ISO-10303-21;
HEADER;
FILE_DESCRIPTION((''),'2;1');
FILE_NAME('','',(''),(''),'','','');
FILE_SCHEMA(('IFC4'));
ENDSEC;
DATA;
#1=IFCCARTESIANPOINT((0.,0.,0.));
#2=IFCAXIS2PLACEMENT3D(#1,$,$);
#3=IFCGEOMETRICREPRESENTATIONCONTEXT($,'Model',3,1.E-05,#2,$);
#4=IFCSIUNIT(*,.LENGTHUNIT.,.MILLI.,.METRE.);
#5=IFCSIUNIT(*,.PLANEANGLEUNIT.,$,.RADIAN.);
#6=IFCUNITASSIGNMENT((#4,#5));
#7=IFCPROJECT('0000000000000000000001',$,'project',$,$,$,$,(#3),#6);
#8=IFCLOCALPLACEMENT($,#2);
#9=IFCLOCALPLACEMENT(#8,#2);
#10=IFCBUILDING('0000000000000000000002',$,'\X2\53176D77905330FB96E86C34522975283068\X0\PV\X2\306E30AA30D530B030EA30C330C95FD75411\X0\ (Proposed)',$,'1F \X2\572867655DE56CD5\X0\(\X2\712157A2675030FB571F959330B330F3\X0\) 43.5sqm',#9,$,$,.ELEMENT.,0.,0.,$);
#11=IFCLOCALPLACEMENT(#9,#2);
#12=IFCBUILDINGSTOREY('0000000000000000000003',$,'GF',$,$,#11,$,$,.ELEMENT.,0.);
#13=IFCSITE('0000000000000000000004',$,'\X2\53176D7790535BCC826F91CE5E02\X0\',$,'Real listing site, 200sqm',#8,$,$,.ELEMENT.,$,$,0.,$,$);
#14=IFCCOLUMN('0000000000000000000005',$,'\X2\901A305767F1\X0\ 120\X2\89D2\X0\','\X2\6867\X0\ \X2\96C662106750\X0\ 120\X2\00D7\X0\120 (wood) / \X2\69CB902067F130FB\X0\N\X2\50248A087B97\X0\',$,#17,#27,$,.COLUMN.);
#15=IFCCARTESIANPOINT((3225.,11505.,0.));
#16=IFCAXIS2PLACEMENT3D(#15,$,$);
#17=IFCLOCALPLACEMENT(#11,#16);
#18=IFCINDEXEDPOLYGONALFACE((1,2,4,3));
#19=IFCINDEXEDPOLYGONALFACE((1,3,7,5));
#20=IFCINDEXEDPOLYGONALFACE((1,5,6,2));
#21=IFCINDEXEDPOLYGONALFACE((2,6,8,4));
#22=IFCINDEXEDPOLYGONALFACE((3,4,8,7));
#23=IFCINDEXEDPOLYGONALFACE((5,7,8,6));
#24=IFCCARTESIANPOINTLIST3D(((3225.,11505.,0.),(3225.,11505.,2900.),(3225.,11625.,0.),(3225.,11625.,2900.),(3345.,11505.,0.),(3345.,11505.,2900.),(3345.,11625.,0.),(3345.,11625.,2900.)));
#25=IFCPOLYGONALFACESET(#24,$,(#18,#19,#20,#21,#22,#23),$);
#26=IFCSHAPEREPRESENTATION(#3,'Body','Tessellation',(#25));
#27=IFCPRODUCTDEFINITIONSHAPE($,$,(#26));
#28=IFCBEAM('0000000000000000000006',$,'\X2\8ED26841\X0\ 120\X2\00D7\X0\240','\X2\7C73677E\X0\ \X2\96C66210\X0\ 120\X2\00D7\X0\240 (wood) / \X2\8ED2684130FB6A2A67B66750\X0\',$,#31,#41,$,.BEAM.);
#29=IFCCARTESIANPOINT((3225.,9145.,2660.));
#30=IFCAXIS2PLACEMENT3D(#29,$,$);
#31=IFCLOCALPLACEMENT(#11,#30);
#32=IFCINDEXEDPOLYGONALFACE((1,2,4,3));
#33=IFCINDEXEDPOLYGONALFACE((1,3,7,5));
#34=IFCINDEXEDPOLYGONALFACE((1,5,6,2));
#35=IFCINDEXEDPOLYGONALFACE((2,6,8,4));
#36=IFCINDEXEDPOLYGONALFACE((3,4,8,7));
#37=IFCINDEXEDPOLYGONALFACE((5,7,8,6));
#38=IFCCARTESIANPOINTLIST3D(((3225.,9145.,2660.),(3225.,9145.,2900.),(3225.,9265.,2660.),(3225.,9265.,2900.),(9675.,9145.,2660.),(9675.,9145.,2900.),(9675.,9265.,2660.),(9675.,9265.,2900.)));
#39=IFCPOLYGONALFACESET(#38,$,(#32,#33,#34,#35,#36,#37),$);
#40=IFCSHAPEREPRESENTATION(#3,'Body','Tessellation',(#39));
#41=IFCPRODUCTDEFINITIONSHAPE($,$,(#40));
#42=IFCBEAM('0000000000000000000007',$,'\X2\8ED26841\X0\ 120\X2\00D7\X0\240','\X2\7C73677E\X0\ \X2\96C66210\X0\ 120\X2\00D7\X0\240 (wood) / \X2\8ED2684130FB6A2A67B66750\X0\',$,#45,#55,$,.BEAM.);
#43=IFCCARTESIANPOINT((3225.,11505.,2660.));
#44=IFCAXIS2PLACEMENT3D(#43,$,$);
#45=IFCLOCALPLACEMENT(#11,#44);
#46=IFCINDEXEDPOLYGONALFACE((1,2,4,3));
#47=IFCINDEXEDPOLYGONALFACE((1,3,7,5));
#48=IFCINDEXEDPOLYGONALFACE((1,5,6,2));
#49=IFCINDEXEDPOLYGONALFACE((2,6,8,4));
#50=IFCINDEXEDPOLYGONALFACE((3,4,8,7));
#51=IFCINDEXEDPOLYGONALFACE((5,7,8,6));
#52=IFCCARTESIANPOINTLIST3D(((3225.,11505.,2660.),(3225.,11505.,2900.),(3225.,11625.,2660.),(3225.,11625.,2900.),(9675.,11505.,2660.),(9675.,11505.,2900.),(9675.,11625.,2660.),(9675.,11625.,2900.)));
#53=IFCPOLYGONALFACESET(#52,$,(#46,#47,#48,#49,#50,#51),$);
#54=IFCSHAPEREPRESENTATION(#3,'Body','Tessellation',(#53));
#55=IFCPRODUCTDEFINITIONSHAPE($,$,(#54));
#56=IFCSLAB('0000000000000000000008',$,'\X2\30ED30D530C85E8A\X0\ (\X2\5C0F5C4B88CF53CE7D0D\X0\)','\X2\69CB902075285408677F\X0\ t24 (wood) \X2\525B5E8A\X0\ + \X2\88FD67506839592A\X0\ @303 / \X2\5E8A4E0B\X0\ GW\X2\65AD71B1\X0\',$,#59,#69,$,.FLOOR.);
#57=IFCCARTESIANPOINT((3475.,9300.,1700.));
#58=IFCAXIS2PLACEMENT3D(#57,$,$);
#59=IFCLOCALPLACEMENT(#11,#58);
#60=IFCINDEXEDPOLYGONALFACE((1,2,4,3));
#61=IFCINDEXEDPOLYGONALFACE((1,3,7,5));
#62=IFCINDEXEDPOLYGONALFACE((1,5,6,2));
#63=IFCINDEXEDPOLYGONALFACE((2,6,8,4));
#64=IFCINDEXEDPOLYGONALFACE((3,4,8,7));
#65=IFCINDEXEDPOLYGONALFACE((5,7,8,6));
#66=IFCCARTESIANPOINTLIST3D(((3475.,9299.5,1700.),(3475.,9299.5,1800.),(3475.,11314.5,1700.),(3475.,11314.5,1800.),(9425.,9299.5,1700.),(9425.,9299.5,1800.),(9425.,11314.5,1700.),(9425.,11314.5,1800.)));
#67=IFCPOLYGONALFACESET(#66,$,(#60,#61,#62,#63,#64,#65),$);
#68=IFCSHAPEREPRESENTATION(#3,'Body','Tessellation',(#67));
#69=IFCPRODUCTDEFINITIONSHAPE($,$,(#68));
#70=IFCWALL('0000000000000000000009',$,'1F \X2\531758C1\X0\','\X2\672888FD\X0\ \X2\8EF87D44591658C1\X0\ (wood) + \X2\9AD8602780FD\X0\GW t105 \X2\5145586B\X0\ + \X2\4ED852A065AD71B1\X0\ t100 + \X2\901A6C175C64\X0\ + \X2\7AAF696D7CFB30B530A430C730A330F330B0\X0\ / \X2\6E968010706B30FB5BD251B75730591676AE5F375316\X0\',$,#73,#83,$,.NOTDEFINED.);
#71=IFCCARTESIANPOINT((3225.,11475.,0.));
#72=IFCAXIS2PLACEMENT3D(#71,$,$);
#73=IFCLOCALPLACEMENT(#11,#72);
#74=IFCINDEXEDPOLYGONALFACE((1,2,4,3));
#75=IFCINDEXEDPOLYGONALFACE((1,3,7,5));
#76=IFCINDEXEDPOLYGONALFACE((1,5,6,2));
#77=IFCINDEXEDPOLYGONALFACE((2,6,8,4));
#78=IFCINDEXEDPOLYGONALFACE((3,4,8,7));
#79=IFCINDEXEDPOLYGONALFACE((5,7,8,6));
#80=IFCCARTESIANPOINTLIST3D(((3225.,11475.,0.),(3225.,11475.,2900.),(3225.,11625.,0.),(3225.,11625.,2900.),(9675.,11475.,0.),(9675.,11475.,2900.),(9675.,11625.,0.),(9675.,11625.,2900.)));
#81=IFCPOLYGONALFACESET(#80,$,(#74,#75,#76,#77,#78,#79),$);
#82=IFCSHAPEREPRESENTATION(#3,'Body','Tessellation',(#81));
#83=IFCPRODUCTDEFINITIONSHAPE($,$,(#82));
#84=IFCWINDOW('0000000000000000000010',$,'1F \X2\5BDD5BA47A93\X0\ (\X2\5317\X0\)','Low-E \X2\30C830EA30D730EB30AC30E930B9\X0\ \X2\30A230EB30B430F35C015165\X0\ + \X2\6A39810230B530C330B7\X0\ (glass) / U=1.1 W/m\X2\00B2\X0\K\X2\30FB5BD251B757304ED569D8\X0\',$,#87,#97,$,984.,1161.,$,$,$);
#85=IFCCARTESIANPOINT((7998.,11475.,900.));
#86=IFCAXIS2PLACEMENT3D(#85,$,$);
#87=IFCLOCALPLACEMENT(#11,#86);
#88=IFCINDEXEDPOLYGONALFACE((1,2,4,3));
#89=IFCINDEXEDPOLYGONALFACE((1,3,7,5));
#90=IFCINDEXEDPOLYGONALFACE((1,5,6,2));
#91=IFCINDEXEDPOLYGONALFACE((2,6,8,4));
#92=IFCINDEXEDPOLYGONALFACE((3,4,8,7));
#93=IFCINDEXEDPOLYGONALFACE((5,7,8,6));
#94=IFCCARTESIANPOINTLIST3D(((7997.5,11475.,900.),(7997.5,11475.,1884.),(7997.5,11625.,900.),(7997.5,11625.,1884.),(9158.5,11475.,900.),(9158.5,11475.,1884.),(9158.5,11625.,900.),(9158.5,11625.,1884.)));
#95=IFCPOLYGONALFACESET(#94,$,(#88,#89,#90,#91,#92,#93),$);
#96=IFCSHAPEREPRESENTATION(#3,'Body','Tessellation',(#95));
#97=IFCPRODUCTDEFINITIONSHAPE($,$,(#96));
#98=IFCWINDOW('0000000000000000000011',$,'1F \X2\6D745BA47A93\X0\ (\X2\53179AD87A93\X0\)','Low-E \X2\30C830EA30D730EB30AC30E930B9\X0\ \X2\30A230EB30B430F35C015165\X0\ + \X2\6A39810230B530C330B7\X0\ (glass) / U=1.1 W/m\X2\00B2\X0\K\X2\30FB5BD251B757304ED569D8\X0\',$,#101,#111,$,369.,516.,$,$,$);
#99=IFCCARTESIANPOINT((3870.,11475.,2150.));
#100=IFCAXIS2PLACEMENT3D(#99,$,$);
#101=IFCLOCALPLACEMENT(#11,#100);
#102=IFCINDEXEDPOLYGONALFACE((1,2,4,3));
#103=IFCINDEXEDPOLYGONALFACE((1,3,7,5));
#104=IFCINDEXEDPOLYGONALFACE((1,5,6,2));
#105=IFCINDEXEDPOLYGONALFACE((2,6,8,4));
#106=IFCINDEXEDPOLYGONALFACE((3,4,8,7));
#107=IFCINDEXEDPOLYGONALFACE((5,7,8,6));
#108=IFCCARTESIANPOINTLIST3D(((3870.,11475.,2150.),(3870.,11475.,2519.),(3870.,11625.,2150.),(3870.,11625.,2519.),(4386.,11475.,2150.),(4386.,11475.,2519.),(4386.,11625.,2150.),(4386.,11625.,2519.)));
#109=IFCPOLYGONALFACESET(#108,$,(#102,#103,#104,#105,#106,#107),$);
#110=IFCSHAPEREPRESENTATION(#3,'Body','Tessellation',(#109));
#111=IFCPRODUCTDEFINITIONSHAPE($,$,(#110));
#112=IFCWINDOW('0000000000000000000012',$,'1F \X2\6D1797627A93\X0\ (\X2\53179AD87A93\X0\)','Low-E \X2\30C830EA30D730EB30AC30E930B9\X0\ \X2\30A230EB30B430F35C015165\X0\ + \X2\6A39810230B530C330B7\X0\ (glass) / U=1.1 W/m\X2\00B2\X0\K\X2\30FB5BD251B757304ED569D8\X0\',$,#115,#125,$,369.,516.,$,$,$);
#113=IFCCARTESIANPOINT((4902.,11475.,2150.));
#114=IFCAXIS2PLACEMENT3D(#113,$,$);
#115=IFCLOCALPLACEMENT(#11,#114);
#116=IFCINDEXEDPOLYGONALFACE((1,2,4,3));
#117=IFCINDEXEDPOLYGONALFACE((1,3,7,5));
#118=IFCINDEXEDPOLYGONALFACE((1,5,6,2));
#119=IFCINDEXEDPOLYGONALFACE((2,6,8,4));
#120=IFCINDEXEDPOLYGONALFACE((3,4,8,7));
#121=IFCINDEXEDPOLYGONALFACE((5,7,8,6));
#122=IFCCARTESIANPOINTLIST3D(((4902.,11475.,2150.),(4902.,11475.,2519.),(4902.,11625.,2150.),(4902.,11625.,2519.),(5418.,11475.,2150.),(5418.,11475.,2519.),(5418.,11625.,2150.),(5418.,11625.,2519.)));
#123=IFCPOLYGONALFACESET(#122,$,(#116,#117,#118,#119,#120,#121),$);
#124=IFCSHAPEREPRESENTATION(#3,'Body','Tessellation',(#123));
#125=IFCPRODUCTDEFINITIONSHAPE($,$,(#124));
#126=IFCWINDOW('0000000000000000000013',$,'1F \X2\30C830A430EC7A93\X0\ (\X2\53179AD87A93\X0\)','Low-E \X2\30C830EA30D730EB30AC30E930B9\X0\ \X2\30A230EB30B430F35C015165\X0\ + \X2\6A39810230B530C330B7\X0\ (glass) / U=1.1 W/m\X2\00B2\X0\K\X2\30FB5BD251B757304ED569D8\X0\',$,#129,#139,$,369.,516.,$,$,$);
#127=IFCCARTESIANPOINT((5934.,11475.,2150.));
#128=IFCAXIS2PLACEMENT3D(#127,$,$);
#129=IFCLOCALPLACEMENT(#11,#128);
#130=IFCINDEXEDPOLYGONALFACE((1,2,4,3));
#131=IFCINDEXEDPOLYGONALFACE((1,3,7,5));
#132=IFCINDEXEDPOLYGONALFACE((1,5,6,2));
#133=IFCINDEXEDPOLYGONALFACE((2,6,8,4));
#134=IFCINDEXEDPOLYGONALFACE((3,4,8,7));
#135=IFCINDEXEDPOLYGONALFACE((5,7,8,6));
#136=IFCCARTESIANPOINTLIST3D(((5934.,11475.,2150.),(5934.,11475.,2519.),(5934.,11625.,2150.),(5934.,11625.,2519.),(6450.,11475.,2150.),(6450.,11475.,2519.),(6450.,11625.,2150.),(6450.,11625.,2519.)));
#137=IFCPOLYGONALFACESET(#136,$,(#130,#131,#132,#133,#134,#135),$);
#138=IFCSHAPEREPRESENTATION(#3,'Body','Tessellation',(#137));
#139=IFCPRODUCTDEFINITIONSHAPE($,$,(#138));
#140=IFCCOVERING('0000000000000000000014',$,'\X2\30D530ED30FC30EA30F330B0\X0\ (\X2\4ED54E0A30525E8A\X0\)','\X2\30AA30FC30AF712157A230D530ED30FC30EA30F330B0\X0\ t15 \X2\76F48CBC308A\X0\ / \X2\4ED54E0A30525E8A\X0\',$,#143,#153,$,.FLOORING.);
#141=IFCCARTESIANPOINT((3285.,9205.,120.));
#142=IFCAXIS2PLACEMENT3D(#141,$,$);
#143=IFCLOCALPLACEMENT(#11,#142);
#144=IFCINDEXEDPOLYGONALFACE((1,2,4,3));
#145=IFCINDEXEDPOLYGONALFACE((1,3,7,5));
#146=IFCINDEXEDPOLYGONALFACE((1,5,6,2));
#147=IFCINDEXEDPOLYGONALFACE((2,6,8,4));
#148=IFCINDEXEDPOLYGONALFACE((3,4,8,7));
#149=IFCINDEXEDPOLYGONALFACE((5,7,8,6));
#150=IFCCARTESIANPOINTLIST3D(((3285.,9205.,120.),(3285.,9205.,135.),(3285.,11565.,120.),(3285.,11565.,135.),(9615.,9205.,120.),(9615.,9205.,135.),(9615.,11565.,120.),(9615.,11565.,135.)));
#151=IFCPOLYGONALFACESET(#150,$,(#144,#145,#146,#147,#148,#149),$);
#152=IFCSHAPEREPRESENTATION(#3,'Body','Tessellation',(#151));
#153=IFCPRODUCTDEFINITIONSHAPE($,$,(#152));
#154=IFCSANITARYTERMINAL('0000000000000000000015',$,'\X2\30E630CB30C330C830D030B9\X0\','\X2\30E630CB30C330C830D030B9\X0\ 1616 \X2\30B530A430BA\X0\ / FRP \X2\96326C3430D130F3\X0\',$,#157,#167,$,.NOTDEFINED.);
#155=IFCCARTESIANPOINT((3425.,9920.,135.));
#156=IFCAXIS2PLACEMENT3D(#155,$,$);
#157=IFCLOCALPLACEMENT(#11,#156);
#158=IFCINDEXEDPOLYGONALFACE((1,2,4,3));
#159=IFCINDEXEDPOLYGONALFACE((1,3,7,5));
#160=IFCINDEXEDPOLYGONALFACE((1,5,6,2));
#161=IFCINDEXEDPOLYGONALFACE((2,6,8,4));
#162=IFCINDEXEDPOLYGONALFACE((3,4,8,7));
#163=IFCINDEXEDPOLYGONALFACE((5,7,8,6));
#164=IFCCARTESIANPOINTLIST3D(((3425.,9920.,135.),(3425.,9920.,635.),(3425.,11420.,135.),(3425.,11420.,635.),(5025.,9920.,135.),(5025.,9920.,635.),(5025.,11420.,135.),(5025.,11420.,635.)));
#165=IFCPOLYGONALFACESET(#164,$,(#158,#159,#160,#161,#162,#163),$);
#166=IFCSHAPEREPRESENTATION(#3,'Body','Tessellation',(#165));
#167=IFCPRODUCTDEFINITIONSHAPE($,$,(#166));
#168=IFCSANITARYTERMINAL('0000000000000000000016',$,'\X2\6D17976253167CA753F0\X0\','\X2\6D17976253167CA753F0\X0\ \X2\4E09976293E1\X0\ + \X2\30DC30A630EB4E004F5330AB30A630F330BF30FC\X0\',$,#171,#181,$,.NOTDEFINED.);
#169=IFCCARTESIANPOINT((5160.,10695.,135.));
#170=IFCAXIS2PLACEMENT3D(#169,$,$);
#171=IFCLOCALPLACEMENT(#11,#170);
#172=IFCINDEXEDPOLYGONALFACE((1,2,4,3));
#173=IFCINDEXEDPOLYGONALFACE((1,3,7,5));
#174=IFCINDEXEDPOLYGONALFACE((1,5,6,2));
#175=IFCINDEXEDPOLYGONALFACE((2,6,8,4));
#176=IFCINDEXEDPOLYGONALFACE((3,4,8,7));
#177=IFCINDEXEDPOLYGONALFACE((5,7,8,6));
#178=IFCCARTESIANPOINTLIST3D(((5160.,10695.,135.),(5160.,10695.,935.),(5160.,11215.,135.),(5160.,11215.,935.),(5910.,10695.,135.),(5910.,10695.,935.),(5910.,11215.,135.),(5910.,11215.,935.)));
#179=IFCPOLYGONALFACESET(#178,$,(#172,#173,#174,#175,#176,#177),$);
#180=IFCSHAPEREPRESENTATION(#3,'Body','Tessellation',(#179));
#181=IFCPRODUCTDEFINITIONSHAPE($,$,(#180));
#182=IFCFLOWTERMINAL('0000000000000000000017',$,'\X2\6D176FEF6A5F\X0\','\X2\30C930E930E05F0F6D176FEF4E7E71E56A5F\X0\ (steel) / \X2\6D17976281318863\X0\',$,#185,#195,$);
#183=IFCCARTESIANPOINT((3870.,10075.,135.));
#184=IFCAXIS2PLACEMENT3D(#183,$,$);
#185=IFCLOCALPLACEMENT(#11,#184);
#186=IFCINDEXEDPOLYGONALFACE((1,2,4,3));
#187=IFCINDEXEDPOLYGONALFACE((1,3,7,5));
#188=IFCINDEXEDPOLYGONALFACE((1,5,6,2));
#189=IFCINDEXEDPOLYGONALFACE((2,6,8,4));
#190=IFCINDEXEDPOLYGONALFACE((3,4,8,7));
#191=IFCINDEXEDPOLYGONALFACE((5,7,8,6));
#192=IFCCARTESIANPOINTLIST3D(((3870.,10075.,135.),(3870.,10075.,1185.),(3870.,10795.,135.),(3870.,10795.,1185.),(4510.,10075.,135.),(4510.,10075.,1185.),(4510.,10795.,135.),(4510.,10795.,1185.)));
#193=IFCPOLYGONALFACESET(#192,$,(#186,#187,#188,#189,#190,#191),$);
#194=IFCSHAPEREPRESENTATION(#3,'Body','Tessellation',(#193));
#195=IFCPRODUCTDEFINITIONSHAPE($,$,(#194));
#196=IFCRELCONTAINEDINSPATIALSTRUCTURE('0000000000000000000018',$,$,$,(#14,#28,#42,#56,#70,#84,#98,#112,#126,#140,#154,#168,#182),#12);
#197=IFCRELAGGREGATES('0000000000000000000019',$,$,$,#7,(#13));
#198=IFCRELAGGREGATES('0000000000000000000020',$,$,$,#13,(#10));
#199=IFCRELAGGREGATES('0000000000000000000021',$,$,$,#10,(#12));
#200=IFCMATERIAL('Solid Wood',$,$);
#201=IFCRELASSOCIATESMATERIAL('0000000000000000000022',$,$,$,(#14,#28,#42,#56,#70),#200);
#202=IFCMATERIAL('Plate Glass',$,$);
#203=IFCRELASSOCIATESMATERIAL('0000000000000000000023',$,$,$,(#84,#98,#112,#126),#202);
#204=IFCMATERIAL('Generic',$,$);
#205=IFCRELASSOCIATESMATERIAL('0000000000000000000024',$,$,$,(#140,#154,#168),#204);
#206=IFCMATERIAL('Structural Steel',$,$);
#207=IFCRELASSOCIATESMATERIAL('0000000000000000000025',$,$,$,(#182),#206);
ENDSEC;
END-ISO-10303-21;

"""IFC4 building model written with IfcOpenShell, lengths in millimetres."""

from ifc_helpers import new_model, si_unit, frame, frame_2d, origin, place, context, project, spatial, rectangle, extrude, material, element, fill, save


model = new_model("IFC4")

# Units and contexts
model_context = context("Model", 3, precision=1e-05, world=origin())
ifc_project = project(units=[si_unit("LENGTHUNIT", "METRE", prefix="MILLI"), si_unit("PLANEANGLEUNIT", "RADIAN")], contexts=[model_context])

# Site, building, storey
site_placement = place(None, origin())
site = spatial("IfcSite", under=ifc_project, at=site_placement, Name="北海道富良野市", ObjectType="Real listing site, 200sqm", CompositionType="ELEMENT", RefElevation=0.0)
building_placement = place(site_placement, origin())
building = spatial("IfcBuilding", under=site, at=building_placement, Name="北海道・雨水利用とPVのオフグリッド志向 (Proposed)", ObjectType="1F 在来工法(無垢材・土間コン) 43.5sqm", CompositionType="ELEMENT", ElevationOfRefHeight=0.0, ElevationOfTerrain=0.0)
storey_placement = place(building_placement, origin())
storey = spatial("IfcBuildingStorey", under=building, at=storey_placement, Name="GF", CompositionType="ELEMENT", Elevation=0.0)

# Column
ifc_material_1 = material(Name="Solid Wood")
column_placement = place(storey_placement, frame((3225.0, 11505.0, 0.0)))
element("IfcColumn", 1, at=column_placement, inside=storey, material=ifc_material_1, Name="通し柱 120角", Description="桧 集成材 120×120 (wood) / 構造柱・N値計算", PredefinedType="COLUMN", context=model_context, shape_type="SweptSolid", body=[
    extrude(rectangle(XDim=120.0, YDim=120.0, at=frame_2d((60.0, 60.0))), frame((3225.0, 11505.0, 0.0)), (0.0, 0.0, 1.0), 2900.0),
])

# Beams
beam_1_placement = place(storey_placement, frame((3225.0, 9145.0, 2660.0)))
element("IfcBeam", 2, at=beam_1_placement, inside=storey, material=ifc_material_1, Name="軒桁 120×240", Description="米松 集成 120×240 (wood) / 軒桁・横架材", PredefinedType="BEAM", context=model_context, shape_type="SweptSolid", body=[
    extrude(rectangle(XDim=6450.0, YDim=120.0, at=frame_2d((3225.0, 60.0))), frame((3225.0, 9145.0, 2660.0)), (0.0, 0.0, 1.0), 240.0),
])
beam_2_placement = place(storey_placement, frame((3225.0, 11505.0, 2660.0)))
element("IfcBeam", 3, at=beam_2_placement, inside=storey, material=ifc_material_1, Name="軒桁 120×240", Description="米松 集成 120×240 (wood) / 軒桁・横架材", PredefinedType="BEAM", context=model_context, shape_type="SweptSolid", body=[
    extrude(rectangle(XDim=6450.0, YDim=120.0, at=frame_2d((3225.0, 60.0))), frame((3225.0, 11505.0, 2660.0)), (0.0, 0.0, 1.0), 240.0),
])

# Slab
slab_placement = place(storey_placement, frame((3475.0, 9300.0, 1700.0)))
element("IfcSlab", 4, at=slab_placement, inside=storey, material=ifc_material_1, Name="ロフト床 (小屋裏収納)", Description="構造用合板 t24 (wood) 剛床 + 製材根太 @303 / 床下 GW断熱", PredefinedType="FLOOR", context=model_context, shape_type="SweptSolid", body=[
    extrude(rectangle(XDim=5950.0, YDim=2015.0, at=frame_2d((2975.0, 1007.0))), frame((3475.0, 9300.0, 1700.0)), (0.0, 0.0, 1.0), 100.0),
])

# Wall, openings, windows
wall_1_placement = place(storey_placement, frame((3225.0, 11475.0, 0.0)))
wall_1 = element("IfcWall", 5, at=wall_1_placement, inside=storey, material=ifc_material_1, Name="1F 北壁", Description="木製 軸組外壁 (wood) + 高性能GW t105 充填 + 付加断熱 t100 + 通気層 + 窯業系サイディング / 準耐火・寒冷地外皮強化", PredefinedType="NOTDEFINED", context=model_context, shape_type="SweptSolid", body=[
    extrude(rectangle(XDim=6450.0, YDim=150.0, at=frame_2d((3225.0, 75.0))), frame((3225.0, 11475.0, 0.0)), (0.0, 0.0, 1.0), 2900.0),
])
opening_1_placement = place(storey_placement, frame((7998.0, 11475.0, 900.0)))
opening_1 = element("IfcOpeningElement", 6, at=opening_1_placement, cuts=wall_1, PredefinedType="NOTDEFINED", context=model_context, shape_type="SweptSolid", body=[
    extrude(rectangle(XDim=1161.0, YDim=150.0, at=frame_2d((580.0, 75.0))), frame((7998.0, 11475.0, 900.0)), (0.0, 0.0, 1.0), 984.0),
])
opening_2_placement = place(storey_placement, frame((3870.0, 11475.0, 2150.0)))
opening_2 = element("IfcOpeningElement", 7, at=opening_2_placement, cuts=wall_1, PredefinedType="NOTDEFINED", context=model_context, shape_type="SweptSolid", body=[
    extrude(rectangle(XDim=516.0, YDim=150.0, at=frame_2d((258.0, 75.0))), frame((3870.0, 11475.0, 2150.0)), (0.0, 0.0, 1.0), 369.0),
])
opening_3_placement = place(storey_placement, frame((4902.0, 11475.0, 2150.0)))
opening_3 = element("IfcOpeningElement", 8, at=opening_3_placement, cuts=wall_1, PredefinedType="NOTDEFINED", context=model_context, shape_type="SweptSolid", body=[
    extrude(rectangle(XDim=516.0, YDim=150.0, at=frame_2d((258.0, 75.0))), frame((4902.0, 11475.0, 2150.0)), (0.0, 0.0, 1.0), 369.0),
])
opening_4_placement = place(storey_placement, frame((5934.0, 11475.0, 2150.0)))
opening_4 = element("IfcOpeningElement", 9, at=opening_4_placement, cuts=wall_1, PredefinedType="NOTDEFINED", context=model_context, shape_type="SweptSolid", body=[
    extrude(rectangle(XDim=516.0, YDim=150.0, at=frame_2d((258.0, 75.0))), frame((5934.0, 11475.0, 2150.0)), (0.0, 0.0, 1.0), 369.0),
])
ifc_material_2 = material(Name="Plate Glass")
window_1_placement = place(storey_placement, frame((7998.0, 11475.0, 900.0)))
window_1 = element("IfcWindow", 10, at=window_1_placement, inside=storey, material=ifc_material_2, Name="1F 寝室窓 (北)", Description="Low-E トリプルガラス アルゴン封入 + 樹脂サッシ (glass) / U=1.1 W/m²K・寒冷地仕様", OverallHeight=984.0, OverallWidth=1161.0, context=model_context, shape_type="SweptSolid", body=[
    extrude(rectangle(XDim=1161.0, YDim=150.0, at=frame_2d((580.0, 75.0))), frame((7998.0, 11475.0, 900.0)), (0.0, 0.0, 1.0), 984.0),
])
fill(opening_1, window_1)
window_2_placement = place(storey_placement, frame((3870.0, 11475.0, 2150.0)))
window_2 = element("IfcWindow", 11, at=window_2_placement, inside=storey, material=ifc_material_2, Name="1F 浴室窓 (北高窓)", Description="Low-E トリプルガラス アルゴン封入 + 樹脂サッシ (glass) / U=1.1 W/m²K・寒冷地仕様", OverallHeight=369.0, OverallWidth=516.0, context=model_context, shape_type="SweptSolid", body=[
    extrude(rectangle(XDim=516.0, YDim=150.0, at=frame_2d((258.0, 75.0))), frame((3870.0, 11475.0, 2150.0)), (0.0, 0.0, 1.0), 369.0),
])
fill(opening_2, window_2)
window_3_placement = place(storey_placement, frame((4902.0, 11475.0, 2150.0)))
window_3 = element("IfcWindow", 12, at=window_3_placement, inside=storey, material=ifc_material_2, Name="1F 洗面窓 (北高窓)", Description="Low-E トリプルガラス アルゴン封入 + 樹脂サッシ (glass) / U=1.1 W/m²K・寒冷地仕様", OverallHeight=369.0, OverallWidth=516.0, context=model_context, shape_type="SweptSolid", body=[
    extrude(rectangle(XDim=516.0, YDim=150.0, at=frame_2d((258.0, 75.0))), frame((4902.0, 11475.0, 2150.0)), (0.0, 0.0, 1.0), 369.0),
])
fill(opening_3, window_3)
window_4_placement = place(storey_placement, frame((5934.0, 11475.0, 2150.0)))
window_4 = element("IfcWindow", 13, at=window_4_placement, inside=storey, material=ifc_material_2, Name="1F トイレ窓 (北高窓)", Description="Low-E トリプルガラス アルゴン封入 + 樹脂サッシ (glass) / U=1.1 W/m²K・寒冷地仕様", OverallHeight=369.0, OverallWidth=516.0, context=model_context, shape_type="SweptSolid", body=[
    extrude(rectangle(XDim=516.0, YDim=150.0, at=frame_2d((258.0, 75.0))), frame((5934.0, 11475.0, 2150.0)), (0.0, 0.0, 1.0), 369.0),
])
fill(opening_4, window_4)

# Covering
ifc_material_3 = material(Name="Generic")
covering_placement = place(storey_placement, frame((3285.0, 9205.0, 120.0)))
element("IfcCovering", 14, at=covering_placement, inside=storey, material=ifc_material_3, Name="フローリング (仕上げ床)", Description="オーク無垢フローリング t15 直貼り / 仕上げ床", PredefinedType="FLOORING", context=model_context, shape_type="SweptSolid", body=[
    extrude(rectangle(XDim=6330.0, YDim=2360.0, at=frame_2d((3165.0, 1180.0))), frame((3285.0, 9205.0, 120.0)), (0.0, 0.0, 1.0), 15.0),
])

# Sanitary terminals
sanitary_terminal_1_placement = place(storey_placement, frame((3425.0, 9920.0, 135.0)))
element("IfcSanitaryTerminal", 15, at=sanitary_terminal_1_placement, inside=storey, material=ifc_material_3, Name="ユニットバス", Description="ユニットバス 1616 サイズ / FRP 防水パン", PredefinedType="NOTDEFINED", context=model_context, shape_type="SweptSolid", body=[
    extrude(rectangle(XDim=1600.0, YDim=1500.0, at=frame_2d((800.0, 750.0))), frame((3425.0, 9920.0, 135.0)), (0.0, 0.0, 1.0), 500.0),
])
sanitary_terminal_2_placement = place(storey_placement, frame((5160.0, 10695.0, 135.0)))
element("IfcSanitaryTerminal", 16, at=sanitary_terminal_2_placement, inside=storey, material=ifc_material_3, Name="洗面化粧台", Description="洗面化粧台 三面鏡 + ボウル一体カウンター", PredefinedType="NOTDEFINED", context=model_context, shape_type="SweptSolid", body=[
    extrude(rectangle(XDim=750.0, YDim=520.0, at=frame_2d((375.0, 260.0))), frame((5160.0, 10695.0, 135.0)), (0.0, 0.0, 1.0), 800.0),
])

# Flow terminal
ifc_material_4 = material(Name="Structural Steel")
flow_terminal_placement = place(storey_placement, frame((3870.0, 10075.0, 135.0)))
element("IfcFlowTerminal", 17, at=flow_terminal_placement, inside=storey, material=ifc_material_4, Name="洗濯機", Description="ドラム式洗濯乾燥機 (steel) / 洗面脱衣", context=model_context, shape_type="SweptSolid", body=[
    extrude(rectangle(XDim=640.0, YDim=720.0, at=frame_2d((320.0, 360.0))), frame((3870.0, 10075.0, 135.0)), (0.0, 0.0, 1.0), 1050.0),
])

save(model, "model.ifc")
